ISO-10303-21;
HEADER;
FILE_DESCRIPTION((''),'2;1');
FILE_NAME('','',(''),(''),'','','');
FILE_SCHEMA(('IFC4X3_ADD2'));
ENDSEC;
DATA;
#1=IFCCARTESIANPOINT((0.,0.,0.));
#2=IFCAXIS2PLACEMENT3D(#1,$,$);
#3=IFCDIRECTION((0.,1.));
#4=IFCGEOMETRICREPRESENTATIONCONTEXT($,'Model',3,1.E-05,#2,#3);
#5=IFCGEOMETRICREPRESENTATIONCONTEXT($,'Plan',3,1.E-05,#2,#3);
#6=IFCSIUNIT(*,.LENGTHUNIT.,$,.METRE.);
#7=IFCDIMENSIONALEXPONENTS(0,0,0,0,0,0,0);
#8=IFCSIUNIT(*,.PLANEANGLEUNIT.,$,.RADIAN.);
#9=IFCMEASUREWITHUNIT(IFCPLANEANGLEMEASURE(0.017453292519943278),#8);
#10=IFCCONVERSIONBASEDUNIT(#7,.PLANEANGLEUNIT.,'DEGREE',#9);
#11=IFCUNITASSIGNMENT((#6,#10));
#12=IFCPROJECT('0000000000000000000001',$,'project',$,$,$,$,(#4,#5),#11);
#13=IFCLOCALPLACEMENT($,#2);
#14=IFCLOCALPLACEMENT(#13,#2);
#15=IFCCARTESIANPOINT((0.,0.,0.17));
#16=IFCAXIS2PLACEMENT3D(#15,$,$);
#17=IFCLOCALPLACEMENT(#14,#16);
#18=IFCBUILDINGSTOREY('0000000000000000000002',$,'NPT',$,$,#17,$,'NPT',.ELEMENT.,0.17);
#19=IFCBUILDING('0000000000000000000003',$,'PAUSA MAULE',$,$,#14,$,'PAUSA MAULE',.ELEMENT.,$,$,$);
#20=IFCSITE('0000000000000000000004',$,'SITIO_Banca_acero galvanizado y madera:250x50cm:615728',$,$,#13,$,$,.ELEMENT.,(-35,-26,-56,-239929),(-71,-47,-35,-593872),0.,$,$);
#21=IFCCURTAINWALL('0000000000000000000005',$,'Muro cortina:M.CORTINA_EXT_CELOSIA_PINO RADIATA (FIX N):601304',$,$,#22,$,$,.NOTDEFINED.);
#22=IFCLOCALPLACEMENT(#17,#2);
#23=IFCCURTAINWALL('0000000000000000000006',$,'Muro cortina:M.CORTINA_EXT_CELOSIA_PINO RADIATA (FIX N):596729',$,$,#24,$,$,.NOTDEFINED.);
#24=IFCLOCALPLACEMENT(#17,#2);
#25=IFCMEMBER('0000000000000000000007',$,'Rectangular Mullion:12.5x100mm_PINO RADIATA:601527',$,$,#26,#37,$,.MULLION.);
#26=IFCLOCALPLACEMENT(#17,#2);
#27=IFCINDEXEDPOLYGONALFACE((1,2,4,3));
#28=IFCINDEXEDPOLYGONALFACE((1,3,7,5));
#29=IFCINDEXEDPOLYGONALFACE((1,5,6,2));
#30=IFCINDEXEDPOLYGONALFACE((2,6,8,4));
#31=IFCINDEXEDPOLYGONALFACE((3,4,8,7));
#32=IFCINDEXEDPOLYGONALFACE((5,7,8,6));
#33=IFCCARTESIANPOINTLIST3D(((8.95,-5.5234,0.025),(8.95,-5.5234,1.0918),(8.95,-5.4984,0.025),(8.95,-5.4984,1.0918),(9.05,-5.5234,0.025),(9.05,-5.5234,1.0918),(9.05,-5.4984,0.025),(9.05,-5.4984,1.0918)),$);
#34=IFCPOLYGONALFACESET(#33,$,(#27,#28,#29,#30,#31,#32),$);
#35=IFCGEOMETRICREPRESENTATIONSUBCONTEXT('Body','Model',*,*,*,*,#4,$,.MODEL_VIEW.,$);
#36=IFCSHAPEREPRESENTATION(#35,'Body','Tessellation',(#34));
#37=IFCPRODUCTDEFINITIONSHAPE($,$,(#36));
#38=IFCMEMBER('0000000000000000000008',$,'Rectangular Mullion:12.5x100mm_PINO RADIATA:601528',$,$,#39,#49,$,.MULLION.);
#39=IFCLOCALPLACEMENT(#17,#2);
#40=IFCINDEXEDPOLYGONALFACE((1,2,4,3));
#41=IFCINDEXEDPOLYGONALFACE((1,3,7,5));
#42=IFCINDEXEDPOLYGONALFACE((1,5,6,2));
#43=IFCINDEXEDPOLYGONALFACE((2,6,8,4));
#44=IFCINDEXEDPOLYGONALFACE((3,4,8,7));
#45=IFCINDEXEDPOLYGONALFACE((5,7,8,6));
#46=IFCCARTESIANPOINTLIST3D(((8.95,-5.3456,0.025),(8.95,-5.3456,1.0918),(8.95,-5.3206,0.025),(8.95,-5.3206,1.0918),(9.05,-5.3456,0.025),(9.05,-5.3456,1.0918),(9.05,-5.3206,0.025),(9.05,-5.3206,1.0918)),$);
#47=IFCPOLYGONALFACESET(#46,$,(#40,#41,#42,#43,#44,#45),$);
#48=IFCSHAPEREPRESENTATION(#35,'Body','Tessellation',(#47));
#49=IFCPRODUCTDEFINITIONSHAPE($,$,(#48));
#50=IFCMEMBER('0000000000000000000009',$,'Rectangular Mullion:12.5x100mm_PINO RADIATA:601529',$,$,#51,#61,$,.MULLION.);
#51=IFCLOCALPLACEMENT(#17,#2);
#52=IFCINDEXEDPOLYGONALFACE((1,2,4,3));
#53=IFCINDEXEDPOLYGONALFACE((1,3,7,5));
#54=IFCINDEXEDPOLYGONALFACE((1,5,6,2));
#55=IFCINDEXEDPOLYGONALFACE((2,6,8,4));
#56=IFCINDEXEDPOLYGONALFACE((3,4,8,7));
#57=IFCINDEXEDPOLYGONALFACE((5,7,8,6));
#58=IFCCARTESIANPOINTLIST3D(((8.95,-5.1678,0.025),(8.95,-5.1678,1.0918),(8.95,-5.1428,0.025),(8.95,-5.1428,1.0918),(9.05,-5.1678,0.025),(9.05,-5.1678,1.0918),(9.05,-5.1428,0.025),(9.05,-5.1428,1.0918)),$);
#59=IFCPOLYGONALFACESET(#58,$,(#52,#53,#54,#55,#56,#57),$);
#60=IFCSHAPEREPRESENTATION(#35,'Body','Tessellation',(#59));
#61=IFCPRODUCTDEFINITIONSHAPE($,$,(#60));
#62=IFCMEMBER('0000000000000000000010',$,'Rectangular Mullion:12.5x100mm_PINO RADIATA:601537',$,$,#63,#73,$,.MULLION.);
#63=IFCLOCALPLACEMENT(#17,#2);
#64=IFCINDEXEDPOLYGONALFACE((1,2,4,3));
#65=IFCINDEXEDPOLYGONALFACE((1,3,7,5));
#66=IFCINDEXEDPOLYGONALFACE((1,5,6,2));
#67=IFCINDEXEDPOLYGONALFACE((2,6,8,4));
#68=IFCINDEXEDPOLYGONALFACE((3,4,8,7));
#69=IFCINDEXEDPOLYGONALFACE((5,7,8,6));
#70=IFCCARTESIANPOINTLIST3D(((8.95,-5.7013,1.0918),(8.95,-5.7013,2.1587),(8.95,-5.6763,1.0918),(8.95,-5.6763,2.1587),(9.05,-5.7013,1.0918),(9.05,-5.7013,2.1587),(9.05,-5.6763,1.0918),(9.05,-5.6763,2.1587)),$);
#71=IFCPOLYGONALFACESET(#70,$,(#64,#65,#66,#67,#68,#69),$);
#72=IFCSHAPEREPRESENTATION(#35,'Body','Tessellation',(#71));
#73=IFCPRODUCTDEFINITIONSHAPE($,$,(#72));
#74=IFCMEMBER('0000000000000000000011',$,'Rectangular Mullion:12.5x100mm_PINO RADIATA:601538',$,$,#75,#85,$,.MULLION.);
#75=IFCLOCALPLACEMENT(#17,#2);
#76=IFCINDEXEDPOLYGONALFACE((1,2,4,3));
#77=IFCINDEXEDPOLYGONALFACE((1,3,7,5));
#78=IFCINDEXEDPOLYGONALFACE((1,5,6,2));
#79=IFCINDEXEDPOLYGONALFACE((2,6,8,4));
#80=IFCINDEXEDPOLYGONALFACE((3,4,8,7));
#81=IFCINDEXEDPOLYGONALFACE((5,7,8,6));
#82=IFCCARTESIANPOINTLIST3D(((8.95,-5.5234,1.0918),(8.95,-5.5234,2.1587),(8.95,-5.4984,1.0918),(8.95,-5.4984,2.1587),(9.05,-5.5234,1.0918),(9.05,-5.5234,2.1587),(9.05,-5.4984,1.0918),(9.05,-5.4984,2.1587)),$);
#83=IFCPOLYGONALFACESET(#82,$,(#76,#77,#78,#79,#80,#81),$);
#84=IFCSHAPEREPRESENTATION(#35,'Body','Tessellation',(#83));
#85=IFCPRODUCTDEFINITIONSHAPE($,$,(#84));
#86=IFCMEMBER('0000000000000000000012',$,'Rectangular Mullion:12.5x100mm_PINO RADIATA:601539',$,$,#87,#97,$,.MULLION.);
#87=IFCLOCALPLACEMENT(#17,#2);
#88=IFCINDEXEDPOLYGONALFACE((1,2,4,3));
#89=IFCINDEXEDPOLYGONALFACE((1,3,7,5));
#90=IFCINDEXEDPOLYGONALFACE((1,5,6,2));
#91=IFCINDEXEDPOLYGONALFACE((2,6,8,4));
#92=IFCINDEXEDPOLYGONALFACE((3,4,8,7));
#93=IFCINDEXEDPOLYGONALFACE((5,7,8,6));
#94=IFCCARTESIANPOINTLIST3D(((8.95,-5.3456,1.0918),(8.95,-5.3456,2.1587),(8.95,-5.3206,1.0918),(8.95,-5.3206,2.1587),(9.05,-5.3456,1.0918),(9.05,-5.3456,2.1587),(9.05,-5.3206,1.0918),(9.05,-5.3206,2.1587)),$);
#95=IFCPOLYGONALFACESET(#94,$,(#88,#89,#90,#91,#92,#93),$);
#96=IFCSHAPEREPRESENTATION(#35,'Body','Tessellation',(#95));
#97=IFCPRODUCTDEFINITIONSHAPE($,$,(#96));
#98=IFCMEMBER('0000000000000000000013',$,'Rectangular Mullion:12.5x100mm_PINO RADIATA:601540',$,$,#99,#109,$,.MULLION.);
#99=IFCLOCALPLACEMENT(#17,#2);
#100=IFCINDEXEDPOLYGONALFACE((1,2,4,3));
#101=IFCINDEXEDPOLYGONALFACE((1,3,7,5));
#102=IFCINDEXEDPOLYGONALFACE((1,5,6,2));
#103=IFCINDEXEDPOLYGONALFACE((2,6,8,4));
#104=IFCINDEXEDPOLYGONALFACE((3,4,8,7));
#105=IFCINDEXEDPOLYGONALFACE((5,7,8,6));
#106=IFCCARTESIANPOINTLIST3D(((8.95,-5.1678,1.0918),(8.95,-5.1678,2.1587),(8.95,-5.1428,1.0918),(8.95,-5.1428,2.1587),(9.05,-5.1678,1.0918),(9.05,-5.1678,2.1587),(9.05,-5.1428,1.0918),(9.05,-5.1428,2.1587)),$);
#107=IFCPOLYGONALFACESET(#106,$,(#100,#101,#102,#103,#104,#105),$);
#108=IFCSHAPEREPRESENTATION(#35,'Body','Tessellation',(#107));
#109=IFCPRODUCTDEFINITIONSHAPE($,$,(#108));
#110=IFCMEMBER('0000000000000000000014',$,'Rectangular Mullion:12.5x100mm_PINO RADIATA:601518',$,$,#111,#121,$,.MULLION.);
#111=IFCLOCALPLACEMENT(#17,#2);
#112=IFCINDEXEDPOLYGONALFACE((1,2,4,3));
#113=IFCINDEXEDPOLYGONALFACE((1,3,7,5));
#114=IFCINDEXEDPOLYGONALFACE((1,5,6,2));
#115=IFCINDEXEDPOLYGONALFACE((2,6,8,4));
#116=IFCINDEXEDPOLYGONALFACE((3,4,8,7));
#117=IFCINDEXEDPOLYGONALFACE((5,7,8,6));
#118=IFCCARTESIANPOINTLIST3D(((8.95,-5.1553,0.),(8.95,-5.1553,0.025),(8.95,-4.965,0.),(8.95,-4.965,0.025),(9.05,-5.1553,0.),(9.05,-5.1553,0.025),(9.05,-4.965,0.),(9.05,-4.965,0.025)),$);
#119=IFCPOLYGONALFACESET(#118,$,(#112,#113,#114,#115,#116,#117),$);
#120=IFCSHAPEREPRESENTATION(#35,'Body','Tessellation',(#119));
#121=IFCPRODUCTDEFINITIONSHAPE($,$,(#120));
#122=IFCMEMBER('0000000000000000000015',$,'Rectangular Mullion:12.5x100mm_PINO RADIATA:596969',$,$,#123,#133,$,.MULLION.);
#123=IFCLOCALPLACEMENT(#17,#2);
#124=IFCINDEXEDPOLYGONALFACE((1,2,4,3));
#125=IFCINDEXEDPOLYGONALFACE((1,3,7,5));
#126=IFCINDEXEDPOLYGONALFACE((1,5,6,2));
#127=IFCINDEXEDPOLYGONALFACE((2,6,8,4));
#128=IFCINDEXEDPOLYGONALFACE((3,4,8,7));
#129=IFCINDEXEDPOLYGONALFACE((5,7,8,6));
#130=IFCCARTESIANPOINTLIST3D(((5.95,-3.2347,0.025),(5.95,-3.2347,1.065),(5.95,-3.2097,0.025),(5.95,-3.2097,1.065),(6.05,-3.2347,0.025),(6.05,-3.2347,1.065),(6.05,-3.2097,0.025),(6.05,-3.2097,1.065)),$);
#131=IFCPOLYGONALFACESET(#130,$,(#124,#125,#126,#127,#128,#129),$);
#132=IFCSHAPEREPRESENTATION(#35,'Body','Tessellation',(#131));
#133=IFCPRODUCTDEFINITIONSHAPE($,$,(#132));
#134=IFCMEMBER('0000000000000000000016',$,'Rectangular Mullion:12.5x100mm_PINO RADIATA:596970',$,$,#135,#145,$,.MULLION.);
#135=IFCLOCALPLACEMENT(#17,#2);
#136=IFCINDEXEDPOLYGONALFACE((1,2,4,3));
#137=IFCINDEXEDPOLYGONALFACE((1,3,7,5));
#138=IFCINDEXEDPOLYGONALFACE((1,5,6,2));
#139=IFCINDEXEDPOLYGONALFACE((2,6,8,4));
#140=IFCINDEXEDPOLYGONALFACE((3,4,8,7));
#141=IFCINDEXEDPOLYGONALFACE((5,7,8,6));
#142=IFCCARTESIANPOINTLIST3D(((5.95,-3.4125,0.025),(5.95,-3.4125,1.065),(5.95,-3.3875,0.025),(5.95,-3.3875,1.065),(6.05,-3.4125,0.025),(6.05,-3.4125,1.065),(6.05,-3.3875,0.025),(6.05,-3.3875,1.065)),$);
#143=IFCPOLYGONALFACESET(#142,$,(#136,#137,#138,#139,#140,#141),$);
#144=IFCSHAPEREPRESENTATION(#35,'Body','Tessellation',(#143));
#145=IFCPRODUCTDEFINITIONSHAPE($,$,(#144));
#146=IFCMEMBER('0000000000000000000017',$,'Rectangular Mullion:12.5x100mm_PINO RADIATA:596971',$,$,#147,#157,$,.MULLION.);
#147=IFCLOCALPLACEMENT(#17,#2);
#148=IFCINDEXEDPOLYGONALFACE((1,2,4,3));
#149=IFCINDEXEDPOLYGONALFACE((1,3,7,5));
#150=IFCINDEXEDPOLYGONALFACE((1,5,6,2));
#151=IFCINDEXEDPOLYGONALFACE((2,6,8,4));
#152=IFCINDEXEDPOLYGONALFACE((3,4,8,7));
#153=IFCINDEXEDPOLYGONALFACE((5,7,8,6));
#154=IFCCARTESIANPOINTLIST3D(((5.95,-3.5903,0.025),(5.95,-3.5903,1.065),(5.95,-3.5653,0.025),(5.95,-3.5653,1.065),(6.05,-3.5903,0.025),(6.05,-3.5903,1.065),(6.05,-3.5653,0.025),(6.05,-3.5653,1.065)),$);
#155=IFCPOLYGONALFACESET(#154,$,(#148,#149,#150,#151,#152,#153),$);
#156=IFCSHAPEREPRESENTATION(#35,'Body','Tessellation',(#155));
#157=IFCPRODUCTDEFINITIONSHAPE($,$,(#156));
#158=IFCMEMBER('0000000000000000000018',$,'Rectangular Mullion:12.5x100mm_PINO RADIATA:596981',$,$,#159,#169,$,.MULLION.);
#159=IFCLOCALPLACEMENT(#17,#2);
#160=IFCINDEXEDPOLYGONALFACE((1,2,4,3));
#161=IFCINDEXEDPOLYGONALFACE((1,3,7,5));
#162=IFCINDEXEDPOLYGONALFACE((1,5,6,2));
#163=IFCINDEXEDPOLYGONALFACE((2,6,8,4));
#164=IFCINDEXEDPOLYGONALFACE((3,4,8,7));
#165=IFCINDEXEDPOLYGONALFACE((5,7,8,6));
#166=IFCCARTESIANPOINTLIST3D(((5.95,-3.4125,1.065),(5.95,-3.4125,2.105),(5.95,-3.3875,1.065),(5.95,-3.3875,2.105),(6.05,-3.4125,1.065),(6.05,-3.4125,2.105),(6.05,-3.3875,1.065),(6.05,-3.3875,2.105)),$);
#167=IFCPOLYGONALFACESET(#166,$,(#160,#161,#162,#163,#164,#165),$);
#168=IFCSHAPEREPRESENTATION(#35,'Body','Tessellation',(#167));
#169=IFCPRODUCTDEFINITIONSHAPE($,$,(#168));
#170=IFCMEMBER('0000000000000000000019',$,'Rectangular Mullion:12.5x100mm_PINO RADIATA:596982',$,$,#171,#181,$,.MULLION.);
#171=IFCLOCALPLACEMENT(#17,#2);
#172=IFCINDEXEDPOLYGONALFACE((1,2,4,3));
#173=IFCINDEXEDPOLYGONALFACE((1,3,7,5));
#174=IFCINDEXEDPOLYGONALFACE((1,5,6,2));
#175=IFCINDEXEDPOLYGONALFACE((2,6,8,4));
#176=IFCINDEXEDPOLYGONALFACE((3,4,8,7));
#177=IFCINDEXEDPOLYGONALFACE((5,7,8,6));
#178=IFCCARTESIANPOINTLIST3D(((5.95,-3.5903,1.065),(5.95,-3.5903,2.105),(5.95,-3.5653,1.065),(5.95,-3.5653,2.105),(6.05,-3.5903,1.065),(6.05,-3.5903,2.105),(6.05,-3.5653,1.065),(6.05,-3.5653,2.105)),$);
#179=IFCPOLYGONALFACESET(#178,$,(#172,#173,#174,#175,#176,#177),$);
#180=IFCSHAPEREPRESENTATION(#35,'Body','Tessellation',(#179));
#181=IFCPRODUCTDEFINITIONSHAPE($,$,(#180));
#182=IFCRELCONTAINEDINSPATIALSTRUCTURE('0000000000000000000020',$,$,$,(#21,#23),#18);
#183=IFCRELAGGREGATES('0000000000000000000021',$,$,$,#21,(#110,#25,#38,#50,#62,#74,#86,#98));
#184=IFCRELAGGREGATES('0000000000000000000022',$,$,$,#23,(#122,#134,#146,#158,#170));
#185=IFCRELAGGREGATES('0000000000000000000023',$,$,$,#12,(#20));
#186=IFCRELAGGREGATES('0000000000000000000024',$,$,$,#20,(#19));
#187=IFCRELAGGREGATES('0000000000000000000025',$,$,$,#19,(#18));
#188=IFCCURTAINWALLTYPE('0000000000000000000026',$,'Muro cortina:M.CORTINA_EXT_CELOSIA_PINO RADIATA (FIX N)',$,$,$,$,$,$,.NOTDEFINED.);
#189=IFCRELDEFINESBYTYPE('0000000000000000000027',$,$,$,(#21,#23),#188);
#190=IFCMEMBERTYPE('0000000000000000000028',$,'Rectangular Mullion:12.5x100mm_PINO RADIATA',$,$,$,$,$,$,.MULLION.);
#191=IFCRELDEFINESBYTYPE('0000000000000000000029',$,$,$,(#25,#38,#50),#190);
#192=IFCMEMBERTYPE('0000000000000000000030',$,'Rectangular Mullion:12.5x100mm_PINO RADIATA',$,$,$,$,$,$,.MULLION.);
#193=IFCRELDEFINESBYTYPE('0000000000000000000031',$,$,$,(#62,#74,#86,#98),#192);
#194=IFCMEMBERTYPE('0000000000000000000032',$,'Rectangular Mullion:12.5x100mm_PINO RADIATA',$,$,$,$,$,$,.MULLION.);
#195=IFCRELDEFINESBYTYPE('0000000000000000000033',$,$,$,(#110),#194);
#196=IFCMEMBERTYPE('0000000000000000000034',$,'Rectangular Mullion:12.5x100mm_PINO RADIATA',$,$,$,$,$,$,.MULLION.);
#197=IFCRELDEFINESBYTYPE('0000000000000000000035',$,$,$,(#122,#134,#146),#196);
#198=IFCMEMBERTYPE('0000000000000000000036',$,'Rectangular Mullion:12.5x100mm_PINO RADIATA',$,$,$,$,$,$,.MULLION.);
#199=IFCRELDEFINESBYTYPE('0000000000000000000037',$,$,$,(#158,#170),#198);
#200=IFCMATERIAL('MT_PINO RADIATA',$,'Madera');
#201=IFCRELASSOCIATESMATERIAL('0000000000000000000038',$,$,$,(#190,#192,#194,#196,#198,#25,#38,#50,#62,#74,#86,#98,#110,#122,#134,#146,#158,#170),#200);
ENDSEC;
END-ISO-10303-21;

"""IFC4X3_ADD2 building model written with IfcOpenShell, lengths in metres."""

from ifc_helpers import new_model, entity, si_unit, converted_unit, direction, frame, frame_2d, origin, origin_2d_with_axis, place, context, subcontext, project, spatial, rectangle, extrude, source, transform, mapped, material, material_profile, profile_set, profile_usage, type_object, type_shapes, element, aggregate, save


model = new_model("IFC4X3_ADD2")

# Units and contexts
model_context = context("Model", 3, precision=1e-05, world=origin(), true_north=direction((0.0, 1.0)))
plan_context = context("Plan", 3, precision=1e-05, world=origin(), true_north=direction((0.0, 1.0)))
body_context = subcontext(model_context, "Body", "Model", "MODEL_VIEW")
ifc_project = project(units=[si_unit("LENGTHUNIT", "METRE"), converted_unit("PLANEANGLEUNIT", "DEGREE", entity("IfcPlaneAngleMeasure", 0.017453292519943278), si_unit("PLANEANGLEUNIT", "RADIAN"), dimensions=[0, 0, 0, 0, 0, 0, 0])], contexts=[model_context, plan_context])

# Site, building, storey
site_placement = place(None, origin())
site = spatial("IfcSite", under=ifc_project, at=site_placement, Name="SITIO_Banca_acero galvanizado y madera:250x50cm:615728", CompositionType="ELEMENT", RefLatitude=(-35, -26, -56, -239929), RefLongitude=(-71, -47, -35, -593872), RefElevation=0.0)
building_placement = place(site_placement, origin())
building = spatial("IfcBuilding", under=site, at=building_placement, Name="PAUSA MAULE", LongName="PAUSA MAULE", CompositionType="ELEMENT")
storey_placement = place(building_placement, frame((0.0, 0.0, 0.17)))
storey = spatial("IfcBuildingStorey", under=building, at=storey_placement, Name="NPT", LongName="NPT", CompositionType="ELEMENT", Elevation=0.17)

# Curtain wall
curtain_wall_type = type_object("IfcCurtainWallType", Name="Muro cortina:M.CORTINA_EXT_CELOSIA_PINO RADIATA (FIX N)", PredefinedType="NOTDEFINED")
curtain_wall_1_placement = place(storey_placement, frame((0.0, 0.0, -0.17)))
curtain_wall_1 = element("IfcCurtainWall", 1, at=curtain_wall_1_placement, inside=storey, type_object=curtain_wall_type, Name="Muro cortina:M.CORTINA_EXT_CELOSIA_PINO RADIATA (FIX N):601304", PredefinedType="NOTDEFINED")
ifc_material = material(Name="MT_PINO RADIATA", Category="Madera")
ifc_material_profile = material_profile(ifc_material, rectangle(XDim=0.025, YDim=0.1, at=frame_2d((0.0, 0.0), x_axis=(1.0, 0.0))), Name="12.5x100mm_PINO RADIATA")
ifc_profile_set = profile_set([ifc_material_profile], Name="12.5x100mm_PINO RADIATA")
ifc_profile_usage = profile_usage(ifc_profile_set)

# Curtain wall
curtain_wall_2_placement = place(storey_placement, frame((0.0, 0.0, -0.17)))
curtain_wall_2 = element("IfcCurtainWall", 2, at=curtain_wall_2_placement, inside=storey, type_object=curtain_wall_type, Name="Muro cortina:M.CORTINA_EXT_CELOSIA_PINO RADIATA (FIX N):596729", PredefinedType="NOTDEFINED")

# Members
member_type_1 = type_object("IfcMemberType", Name="Rectangular Mullion:12.5x100mm_PINO RADIATA", PredefinedType="MULLION", material=ifc_profile_set)
shared_shape_1 = source(origin(), body_context, "Body", "SweptSolid", [
    extrude(rectangle(XDim=0.025, YDim=0.1, at=origin_2d_with_axis()), frame((0.0, 0.0, -1.0668), z_axis=(0.0, 0.0, 1.0), x_axis=(-1.0, 0.0, 0.0)), (0.0, 0.0, 1.0), 1.0668),
])
type_shapes(member_type_1, [shared_shape_1])
member_1_placement = place(curtain_wall_1_placement, frame((9.0, -5.5109, 0.195), z_axis=(0.0, 0.0, -1.0), x_axis=(0.0, 1.0, 0.0)))
member_1 = element("IfcMember", 3, at=member_1_placement, type_object=member_type_1, material=ifc_profile_usage, Name="Rectangular Mullion:12.5x100mm_PINO RADIATA:601527", PredefinedType="MULLION", context=body_context, shape_type="MappedRepresentation", body=[
    mapped(shared_shape_1, transform((0.0, 0.0, 0.0), scale=1.0)),
])
member_2_placement = place(curtain_wall_1_placement, frame((9.0, -5.3331, 0.195), z_axis=(0.0, 0.0, -1.0), x_axis=(0.0, 1.0, 0.0)))
member_2 = element("IfcMember", 4, at=member_2_placement, type_object=member_type_1, material=ifc_profile_usage, Name="Rectangular Mullion:12.5x100mm_PINO RADIATA:601528", PredefinedType="MULLION", context=body_context, shape_type="MappedRepresentation", body=[
    mapped(shared_shape_1, transform((0.0, 0.0, 0.0), scale=1.0)),
])
member_3_placement = place(curtain_wall_1_placement, frame((9.0, -5.1553, 0.195), z_axis=(0.0, 0.0, -1.0), x_axis=(0.0, 1.0, 0.0)))
member_3 = element("IfcMember", 5, at=member_3_placement, type_object=member_type_1, material=ifc_profile_usage, Name="Rectangular Mullion:12.5x100mm_PINO RADIATA:601529", PredefinedType="MULLION", context=body_context, shape_type="MappedRepresentation", body=[
    mapped(shared_shape_1, transform((0.0, 0.0, 0.0), scale=1.0)),
])
member_type_2 = type_object("IfcMemberType", Name="Rectangular Mullion:12.5x100mm_PINO RADIATA", PredefinedType="MULLION", material=ifc_profile_set)
shared_shape_2 = source(origin(), body_context, "Body", "SweptSolid", [
    extrude(rectangle(XDim=0.025, YDim=0.1, at=origin_2d_with_axis()), frame((0.0, 0.0, -1.0668), z_axis=(0.0, 0.0, 1.0), x_axis=(-1.0, 0.0, 0.0)), (0.0, 0.0, 1.0), 1.0668),
])
type_shapes(member_type_2, [shared_shape_2])
member_4_placement = place(curtain_wall_1_placement, frame((9.0, -5.6888, 1.2618), z_axis=(0.0, 0.0, -1.0), x_axis=(0.0, 1.0, 0.0)))
member_4 = element("IfcMember", 6, at=member_4_placement, type_object=member_type_2, material=ifc_profile_usage, Name="Rectangular Mullion:12.5x100mm_PINO RADIATA:601537", PredefinedType="MULLION", context=body_context, shape_type="MappedRepresentation", body=[
    mapped(shared_shape_2, transform((0.0, 0.0, 0.0), scale=1.0)),
])
member_5_placement = place(curtain_wall_1_placement, frame((9.0, -5.5109, 1.2618), z_axis=(0.0, 0.0, -1.0), x_axis=(0.0, 1.0, 0.0)))
member_5 = element("IfcMember", 7, at=member_5_placement, type_object=member_type_2, material=ifc_profile_usage, Name="Rectangular Mullion:12.5x100mm_PINO RADIATA:601538", PredefinedType="MULLION", context=body_context, shape_type="MappedRepresentation", body=[
    mapped(shared_shape_2, transform((0.0, 0.0, 0.0), scale=1.0)),
])
member_6_placement = place(curtain_wall_1_placement, frame((9.0, -5.3331, 1.2618), z_axis=(0.0, 0.0, -1.0), x_axis=(0.0, 1.0, 0.0)))
member_6 = element("IfcMember", 8, at=member_6_placement, type_object=member_type_2, material=ifc_profile_usage, Name="Rectangular Mullion:12.5x100mm_PINO RADIATA:601539", PredefinedType="MULLION", context=body_context, shape_type="MappedRepresentation", body=[
    mapped(shared_shape_2, transform((0.0, 0.0, 0.0), scale=1.0)),
])
member_7_placement = place(curtain_wall_1_placement, frame((9.0, -5.1553, 1.2618), z_axis=(0.0, 0.0, -1.0), x_axis=(0.0, 1.0, 0.0)))
member_7 = element("IfcMember", 9, at=member_7_placement, type_object=member_type_2, material=ifc_profile_usage, Name="Rectangular Mullion:12.5x100mm_PINO RADIATA:601540", PredefinedType="MULLION", context=body_context, shape_type="MappedRepresentation", body=[
    mapped(shared_shape_2, transform((0.0, 0.0, 0.0), scale=1.0)),
])
member_type_3 = type_object("IfcMemberType", Name="Rectangular Mullion:12.5x100mm_PINO RADIATA", PredefinedType="MULLION", material=ifc_profile_set)
shared_shape_3 = source(origin(), body_context, "Body", "SweptSolid", [
    extrude(rectangle(XDim=0.025, YDim=0.1, at=frame_2d((0.0, 0.0), x_axis=(1.0, 0.0))), frame((-0.0125, 0.0, -0.1903), z_axis=(0.0, 0.0, 1.0), x_axis=(-1.0, 0.0, 0.0)), (0.0, 0.0, 1.0), 0.1903),
])
type_shapes(member_type_3, [shared_shape_3])
member_8_placement = place(curtain_wall_1_placement, frame((9.0, -5.1553, 0.17), z_axis=(0.0, -1.0, 0.0), x_axis=(0.0, 0.0, -1.0)))
member_8 = element("IfcMember", 10, at=member_8_placement, type_object=member_type_3, material=ifc_profile_usage, Name="Rectangular Mullion:12.5x100mm_PINO RADIATA:601518", PredefinedType="MULLION", context=body_context, shape_type="MappedRepresentation", body=[
    mapped(shared_shape_3, transform((0.0, 0.0, 0.0), scale=1.0)),
])
aggregate(curtain_wall_1, [member_8, member_1, member_2, member_3, member_4, member_5, member_6, member_7])
member_type_4 = type_object("IfcMemberType", Name="Rectangular Mullion:12.5x100mm_PINO RADIATA", PredefinedType="MULLION", material=ifc_profile_set)
shared_shape_4 = source(origin(), body_context, "Body", "SweptSolid", [
    extrude(rectangle(XDim=0.025, YDim=0.1, at=frame_2d((0.0, 0.0), x_axis=(1.0, 0.0))), frame((0.0, 0.0, -1.04), z_axis=(0.0, 0.0, 1.0), x_axis=(-1.0, 0.0, 0.0)), (0.0, 0.0, 1.0), 1.04),
])
type_shapes(member_type_4, [shared_shape_4])
member_9_placement = place(curtain_wall_2_placement, frame((6.0, -3.2222, 0.195), z_axis=(0.0, 0.0, -1.0), x_axis=(0.0, -1.0, 0.0)))
member_9 = element("IfcMember", 11, at=member_9_placement, type_object=member_type_4, material=ifc_profile_usage, Name="Rectangular Mullion:12.5x100mm_PINO RADIATA:596969", PredefinedType="MULLION", context=body_context, shape_type="MappedRepresentation", body=[
    mapped(shared_shape_4, transform((0.0, 0.0, 0.0), scale=1.0)),
])
member_10_placement = place(curtain_wall_2_placement, frame((6.0, -3.4, 0.195), z_axis=(0.0, 0.0, -1.0), x_axis=(0.0, -1.0, 0.0)))
member_10 = element("IfcMember", 12, at=member_10_placement, type_object=member_type_4, material=ifc_profile_usage, Name="Rectangular Mullion:12.5x100mm_PINO RADIATA:596970", PredefinedType="MULLION", context=body_context, shape_type="MappedRepresentation", body=[
    mapped(shared_shape_4, transform((0.0, 0.0, 0.0), scale=1.0)),
])
member_11_placement = place(curtain_wall_2_placement, frame((6.0, -3.5778, 0.195), z_axis=(0.0, 0.0, -1.0), x_axis=(0.0, -1.0, 0.0)))
member_11 = element("IfcMember", 13, at=member_11_placement, type_object=member_type_4, material=ifc_profile_usage, Name="Rectangular Mullion:12.5x100mm_PINO RADIATA:596971", PredefinedType="MULLION", context=body_context, shape_type="MappedRepresentation", body=[
    mapped(shared_shape_4, transform((0.0, 0.0, 0.0), scale=1.0)),
])
member_type_5 = type_object("IfcMemberType", Name="Rectangular Mullion:12.5x100mm_PINO RADIATA", PredefinedType="MULLION", material=ifc_profile_set)
shared_shape_5 = source(origin(), body_context, "Body", "SweptSolid", [
    extrude(rectangle(XDim=0.025, YDim=0.1, at=origin_2d_with_axis()), frame((0.0, 0.0, -1.04), z_axis=(0.0, 0.0, 1.0), x_axis=(-1.0, 0.0, 0.0)), (0.0, 0.0, 1.0), 1.04),
])
type_shapes(member_type_5, [shared_shape_5])
member_12_placement = place(curtain_wall_2_placement, frame((6.0, -3.4, 1.235), z_axis=(0.0, 0.0, -1.0), x_axis=(0.0, -1.0, 0.0)))
member_12 = element("IfcMember", 14, at=member_12_placement, type_object=member_type_5, material=ifc_profile_usage, Name="Rectangular Mullion:12.5x100mm_PINO RADIATA:596981", PredefinedType="MULLION", context=body_context, shape_type="MappedRepresentation", body=[
    mapped(shared_shape_5, transform((0.0, 0.0, 0.0), scale=1.0)),
])
member_13_placement = place(curtain_wall_2_placement, frame((6.0, -3.5778, 1.235), z_axis=(0.0, 0.0, -1.0), x_axis=(0.0, -1.0, 0.0)))
member_13 = element("IfcMember", 15, at=member_13_placement, type_object=member_type_5, material=ifc_profile_usage, Name="Rectangular Mullion:12.5x100mm_PINO RADIATA:596982", PredefinedType="MULLION", context=body_context, shape_type="MappedRepresentation", body=[
    mapped(shared_shape_5, transform((0.0, 0.0, 0.0), scale=1.0)),
])
aggregate(curtain_wall_2, [member_9, member_10, member_11, member_12, member_13])

save(model, "model.ifc")
